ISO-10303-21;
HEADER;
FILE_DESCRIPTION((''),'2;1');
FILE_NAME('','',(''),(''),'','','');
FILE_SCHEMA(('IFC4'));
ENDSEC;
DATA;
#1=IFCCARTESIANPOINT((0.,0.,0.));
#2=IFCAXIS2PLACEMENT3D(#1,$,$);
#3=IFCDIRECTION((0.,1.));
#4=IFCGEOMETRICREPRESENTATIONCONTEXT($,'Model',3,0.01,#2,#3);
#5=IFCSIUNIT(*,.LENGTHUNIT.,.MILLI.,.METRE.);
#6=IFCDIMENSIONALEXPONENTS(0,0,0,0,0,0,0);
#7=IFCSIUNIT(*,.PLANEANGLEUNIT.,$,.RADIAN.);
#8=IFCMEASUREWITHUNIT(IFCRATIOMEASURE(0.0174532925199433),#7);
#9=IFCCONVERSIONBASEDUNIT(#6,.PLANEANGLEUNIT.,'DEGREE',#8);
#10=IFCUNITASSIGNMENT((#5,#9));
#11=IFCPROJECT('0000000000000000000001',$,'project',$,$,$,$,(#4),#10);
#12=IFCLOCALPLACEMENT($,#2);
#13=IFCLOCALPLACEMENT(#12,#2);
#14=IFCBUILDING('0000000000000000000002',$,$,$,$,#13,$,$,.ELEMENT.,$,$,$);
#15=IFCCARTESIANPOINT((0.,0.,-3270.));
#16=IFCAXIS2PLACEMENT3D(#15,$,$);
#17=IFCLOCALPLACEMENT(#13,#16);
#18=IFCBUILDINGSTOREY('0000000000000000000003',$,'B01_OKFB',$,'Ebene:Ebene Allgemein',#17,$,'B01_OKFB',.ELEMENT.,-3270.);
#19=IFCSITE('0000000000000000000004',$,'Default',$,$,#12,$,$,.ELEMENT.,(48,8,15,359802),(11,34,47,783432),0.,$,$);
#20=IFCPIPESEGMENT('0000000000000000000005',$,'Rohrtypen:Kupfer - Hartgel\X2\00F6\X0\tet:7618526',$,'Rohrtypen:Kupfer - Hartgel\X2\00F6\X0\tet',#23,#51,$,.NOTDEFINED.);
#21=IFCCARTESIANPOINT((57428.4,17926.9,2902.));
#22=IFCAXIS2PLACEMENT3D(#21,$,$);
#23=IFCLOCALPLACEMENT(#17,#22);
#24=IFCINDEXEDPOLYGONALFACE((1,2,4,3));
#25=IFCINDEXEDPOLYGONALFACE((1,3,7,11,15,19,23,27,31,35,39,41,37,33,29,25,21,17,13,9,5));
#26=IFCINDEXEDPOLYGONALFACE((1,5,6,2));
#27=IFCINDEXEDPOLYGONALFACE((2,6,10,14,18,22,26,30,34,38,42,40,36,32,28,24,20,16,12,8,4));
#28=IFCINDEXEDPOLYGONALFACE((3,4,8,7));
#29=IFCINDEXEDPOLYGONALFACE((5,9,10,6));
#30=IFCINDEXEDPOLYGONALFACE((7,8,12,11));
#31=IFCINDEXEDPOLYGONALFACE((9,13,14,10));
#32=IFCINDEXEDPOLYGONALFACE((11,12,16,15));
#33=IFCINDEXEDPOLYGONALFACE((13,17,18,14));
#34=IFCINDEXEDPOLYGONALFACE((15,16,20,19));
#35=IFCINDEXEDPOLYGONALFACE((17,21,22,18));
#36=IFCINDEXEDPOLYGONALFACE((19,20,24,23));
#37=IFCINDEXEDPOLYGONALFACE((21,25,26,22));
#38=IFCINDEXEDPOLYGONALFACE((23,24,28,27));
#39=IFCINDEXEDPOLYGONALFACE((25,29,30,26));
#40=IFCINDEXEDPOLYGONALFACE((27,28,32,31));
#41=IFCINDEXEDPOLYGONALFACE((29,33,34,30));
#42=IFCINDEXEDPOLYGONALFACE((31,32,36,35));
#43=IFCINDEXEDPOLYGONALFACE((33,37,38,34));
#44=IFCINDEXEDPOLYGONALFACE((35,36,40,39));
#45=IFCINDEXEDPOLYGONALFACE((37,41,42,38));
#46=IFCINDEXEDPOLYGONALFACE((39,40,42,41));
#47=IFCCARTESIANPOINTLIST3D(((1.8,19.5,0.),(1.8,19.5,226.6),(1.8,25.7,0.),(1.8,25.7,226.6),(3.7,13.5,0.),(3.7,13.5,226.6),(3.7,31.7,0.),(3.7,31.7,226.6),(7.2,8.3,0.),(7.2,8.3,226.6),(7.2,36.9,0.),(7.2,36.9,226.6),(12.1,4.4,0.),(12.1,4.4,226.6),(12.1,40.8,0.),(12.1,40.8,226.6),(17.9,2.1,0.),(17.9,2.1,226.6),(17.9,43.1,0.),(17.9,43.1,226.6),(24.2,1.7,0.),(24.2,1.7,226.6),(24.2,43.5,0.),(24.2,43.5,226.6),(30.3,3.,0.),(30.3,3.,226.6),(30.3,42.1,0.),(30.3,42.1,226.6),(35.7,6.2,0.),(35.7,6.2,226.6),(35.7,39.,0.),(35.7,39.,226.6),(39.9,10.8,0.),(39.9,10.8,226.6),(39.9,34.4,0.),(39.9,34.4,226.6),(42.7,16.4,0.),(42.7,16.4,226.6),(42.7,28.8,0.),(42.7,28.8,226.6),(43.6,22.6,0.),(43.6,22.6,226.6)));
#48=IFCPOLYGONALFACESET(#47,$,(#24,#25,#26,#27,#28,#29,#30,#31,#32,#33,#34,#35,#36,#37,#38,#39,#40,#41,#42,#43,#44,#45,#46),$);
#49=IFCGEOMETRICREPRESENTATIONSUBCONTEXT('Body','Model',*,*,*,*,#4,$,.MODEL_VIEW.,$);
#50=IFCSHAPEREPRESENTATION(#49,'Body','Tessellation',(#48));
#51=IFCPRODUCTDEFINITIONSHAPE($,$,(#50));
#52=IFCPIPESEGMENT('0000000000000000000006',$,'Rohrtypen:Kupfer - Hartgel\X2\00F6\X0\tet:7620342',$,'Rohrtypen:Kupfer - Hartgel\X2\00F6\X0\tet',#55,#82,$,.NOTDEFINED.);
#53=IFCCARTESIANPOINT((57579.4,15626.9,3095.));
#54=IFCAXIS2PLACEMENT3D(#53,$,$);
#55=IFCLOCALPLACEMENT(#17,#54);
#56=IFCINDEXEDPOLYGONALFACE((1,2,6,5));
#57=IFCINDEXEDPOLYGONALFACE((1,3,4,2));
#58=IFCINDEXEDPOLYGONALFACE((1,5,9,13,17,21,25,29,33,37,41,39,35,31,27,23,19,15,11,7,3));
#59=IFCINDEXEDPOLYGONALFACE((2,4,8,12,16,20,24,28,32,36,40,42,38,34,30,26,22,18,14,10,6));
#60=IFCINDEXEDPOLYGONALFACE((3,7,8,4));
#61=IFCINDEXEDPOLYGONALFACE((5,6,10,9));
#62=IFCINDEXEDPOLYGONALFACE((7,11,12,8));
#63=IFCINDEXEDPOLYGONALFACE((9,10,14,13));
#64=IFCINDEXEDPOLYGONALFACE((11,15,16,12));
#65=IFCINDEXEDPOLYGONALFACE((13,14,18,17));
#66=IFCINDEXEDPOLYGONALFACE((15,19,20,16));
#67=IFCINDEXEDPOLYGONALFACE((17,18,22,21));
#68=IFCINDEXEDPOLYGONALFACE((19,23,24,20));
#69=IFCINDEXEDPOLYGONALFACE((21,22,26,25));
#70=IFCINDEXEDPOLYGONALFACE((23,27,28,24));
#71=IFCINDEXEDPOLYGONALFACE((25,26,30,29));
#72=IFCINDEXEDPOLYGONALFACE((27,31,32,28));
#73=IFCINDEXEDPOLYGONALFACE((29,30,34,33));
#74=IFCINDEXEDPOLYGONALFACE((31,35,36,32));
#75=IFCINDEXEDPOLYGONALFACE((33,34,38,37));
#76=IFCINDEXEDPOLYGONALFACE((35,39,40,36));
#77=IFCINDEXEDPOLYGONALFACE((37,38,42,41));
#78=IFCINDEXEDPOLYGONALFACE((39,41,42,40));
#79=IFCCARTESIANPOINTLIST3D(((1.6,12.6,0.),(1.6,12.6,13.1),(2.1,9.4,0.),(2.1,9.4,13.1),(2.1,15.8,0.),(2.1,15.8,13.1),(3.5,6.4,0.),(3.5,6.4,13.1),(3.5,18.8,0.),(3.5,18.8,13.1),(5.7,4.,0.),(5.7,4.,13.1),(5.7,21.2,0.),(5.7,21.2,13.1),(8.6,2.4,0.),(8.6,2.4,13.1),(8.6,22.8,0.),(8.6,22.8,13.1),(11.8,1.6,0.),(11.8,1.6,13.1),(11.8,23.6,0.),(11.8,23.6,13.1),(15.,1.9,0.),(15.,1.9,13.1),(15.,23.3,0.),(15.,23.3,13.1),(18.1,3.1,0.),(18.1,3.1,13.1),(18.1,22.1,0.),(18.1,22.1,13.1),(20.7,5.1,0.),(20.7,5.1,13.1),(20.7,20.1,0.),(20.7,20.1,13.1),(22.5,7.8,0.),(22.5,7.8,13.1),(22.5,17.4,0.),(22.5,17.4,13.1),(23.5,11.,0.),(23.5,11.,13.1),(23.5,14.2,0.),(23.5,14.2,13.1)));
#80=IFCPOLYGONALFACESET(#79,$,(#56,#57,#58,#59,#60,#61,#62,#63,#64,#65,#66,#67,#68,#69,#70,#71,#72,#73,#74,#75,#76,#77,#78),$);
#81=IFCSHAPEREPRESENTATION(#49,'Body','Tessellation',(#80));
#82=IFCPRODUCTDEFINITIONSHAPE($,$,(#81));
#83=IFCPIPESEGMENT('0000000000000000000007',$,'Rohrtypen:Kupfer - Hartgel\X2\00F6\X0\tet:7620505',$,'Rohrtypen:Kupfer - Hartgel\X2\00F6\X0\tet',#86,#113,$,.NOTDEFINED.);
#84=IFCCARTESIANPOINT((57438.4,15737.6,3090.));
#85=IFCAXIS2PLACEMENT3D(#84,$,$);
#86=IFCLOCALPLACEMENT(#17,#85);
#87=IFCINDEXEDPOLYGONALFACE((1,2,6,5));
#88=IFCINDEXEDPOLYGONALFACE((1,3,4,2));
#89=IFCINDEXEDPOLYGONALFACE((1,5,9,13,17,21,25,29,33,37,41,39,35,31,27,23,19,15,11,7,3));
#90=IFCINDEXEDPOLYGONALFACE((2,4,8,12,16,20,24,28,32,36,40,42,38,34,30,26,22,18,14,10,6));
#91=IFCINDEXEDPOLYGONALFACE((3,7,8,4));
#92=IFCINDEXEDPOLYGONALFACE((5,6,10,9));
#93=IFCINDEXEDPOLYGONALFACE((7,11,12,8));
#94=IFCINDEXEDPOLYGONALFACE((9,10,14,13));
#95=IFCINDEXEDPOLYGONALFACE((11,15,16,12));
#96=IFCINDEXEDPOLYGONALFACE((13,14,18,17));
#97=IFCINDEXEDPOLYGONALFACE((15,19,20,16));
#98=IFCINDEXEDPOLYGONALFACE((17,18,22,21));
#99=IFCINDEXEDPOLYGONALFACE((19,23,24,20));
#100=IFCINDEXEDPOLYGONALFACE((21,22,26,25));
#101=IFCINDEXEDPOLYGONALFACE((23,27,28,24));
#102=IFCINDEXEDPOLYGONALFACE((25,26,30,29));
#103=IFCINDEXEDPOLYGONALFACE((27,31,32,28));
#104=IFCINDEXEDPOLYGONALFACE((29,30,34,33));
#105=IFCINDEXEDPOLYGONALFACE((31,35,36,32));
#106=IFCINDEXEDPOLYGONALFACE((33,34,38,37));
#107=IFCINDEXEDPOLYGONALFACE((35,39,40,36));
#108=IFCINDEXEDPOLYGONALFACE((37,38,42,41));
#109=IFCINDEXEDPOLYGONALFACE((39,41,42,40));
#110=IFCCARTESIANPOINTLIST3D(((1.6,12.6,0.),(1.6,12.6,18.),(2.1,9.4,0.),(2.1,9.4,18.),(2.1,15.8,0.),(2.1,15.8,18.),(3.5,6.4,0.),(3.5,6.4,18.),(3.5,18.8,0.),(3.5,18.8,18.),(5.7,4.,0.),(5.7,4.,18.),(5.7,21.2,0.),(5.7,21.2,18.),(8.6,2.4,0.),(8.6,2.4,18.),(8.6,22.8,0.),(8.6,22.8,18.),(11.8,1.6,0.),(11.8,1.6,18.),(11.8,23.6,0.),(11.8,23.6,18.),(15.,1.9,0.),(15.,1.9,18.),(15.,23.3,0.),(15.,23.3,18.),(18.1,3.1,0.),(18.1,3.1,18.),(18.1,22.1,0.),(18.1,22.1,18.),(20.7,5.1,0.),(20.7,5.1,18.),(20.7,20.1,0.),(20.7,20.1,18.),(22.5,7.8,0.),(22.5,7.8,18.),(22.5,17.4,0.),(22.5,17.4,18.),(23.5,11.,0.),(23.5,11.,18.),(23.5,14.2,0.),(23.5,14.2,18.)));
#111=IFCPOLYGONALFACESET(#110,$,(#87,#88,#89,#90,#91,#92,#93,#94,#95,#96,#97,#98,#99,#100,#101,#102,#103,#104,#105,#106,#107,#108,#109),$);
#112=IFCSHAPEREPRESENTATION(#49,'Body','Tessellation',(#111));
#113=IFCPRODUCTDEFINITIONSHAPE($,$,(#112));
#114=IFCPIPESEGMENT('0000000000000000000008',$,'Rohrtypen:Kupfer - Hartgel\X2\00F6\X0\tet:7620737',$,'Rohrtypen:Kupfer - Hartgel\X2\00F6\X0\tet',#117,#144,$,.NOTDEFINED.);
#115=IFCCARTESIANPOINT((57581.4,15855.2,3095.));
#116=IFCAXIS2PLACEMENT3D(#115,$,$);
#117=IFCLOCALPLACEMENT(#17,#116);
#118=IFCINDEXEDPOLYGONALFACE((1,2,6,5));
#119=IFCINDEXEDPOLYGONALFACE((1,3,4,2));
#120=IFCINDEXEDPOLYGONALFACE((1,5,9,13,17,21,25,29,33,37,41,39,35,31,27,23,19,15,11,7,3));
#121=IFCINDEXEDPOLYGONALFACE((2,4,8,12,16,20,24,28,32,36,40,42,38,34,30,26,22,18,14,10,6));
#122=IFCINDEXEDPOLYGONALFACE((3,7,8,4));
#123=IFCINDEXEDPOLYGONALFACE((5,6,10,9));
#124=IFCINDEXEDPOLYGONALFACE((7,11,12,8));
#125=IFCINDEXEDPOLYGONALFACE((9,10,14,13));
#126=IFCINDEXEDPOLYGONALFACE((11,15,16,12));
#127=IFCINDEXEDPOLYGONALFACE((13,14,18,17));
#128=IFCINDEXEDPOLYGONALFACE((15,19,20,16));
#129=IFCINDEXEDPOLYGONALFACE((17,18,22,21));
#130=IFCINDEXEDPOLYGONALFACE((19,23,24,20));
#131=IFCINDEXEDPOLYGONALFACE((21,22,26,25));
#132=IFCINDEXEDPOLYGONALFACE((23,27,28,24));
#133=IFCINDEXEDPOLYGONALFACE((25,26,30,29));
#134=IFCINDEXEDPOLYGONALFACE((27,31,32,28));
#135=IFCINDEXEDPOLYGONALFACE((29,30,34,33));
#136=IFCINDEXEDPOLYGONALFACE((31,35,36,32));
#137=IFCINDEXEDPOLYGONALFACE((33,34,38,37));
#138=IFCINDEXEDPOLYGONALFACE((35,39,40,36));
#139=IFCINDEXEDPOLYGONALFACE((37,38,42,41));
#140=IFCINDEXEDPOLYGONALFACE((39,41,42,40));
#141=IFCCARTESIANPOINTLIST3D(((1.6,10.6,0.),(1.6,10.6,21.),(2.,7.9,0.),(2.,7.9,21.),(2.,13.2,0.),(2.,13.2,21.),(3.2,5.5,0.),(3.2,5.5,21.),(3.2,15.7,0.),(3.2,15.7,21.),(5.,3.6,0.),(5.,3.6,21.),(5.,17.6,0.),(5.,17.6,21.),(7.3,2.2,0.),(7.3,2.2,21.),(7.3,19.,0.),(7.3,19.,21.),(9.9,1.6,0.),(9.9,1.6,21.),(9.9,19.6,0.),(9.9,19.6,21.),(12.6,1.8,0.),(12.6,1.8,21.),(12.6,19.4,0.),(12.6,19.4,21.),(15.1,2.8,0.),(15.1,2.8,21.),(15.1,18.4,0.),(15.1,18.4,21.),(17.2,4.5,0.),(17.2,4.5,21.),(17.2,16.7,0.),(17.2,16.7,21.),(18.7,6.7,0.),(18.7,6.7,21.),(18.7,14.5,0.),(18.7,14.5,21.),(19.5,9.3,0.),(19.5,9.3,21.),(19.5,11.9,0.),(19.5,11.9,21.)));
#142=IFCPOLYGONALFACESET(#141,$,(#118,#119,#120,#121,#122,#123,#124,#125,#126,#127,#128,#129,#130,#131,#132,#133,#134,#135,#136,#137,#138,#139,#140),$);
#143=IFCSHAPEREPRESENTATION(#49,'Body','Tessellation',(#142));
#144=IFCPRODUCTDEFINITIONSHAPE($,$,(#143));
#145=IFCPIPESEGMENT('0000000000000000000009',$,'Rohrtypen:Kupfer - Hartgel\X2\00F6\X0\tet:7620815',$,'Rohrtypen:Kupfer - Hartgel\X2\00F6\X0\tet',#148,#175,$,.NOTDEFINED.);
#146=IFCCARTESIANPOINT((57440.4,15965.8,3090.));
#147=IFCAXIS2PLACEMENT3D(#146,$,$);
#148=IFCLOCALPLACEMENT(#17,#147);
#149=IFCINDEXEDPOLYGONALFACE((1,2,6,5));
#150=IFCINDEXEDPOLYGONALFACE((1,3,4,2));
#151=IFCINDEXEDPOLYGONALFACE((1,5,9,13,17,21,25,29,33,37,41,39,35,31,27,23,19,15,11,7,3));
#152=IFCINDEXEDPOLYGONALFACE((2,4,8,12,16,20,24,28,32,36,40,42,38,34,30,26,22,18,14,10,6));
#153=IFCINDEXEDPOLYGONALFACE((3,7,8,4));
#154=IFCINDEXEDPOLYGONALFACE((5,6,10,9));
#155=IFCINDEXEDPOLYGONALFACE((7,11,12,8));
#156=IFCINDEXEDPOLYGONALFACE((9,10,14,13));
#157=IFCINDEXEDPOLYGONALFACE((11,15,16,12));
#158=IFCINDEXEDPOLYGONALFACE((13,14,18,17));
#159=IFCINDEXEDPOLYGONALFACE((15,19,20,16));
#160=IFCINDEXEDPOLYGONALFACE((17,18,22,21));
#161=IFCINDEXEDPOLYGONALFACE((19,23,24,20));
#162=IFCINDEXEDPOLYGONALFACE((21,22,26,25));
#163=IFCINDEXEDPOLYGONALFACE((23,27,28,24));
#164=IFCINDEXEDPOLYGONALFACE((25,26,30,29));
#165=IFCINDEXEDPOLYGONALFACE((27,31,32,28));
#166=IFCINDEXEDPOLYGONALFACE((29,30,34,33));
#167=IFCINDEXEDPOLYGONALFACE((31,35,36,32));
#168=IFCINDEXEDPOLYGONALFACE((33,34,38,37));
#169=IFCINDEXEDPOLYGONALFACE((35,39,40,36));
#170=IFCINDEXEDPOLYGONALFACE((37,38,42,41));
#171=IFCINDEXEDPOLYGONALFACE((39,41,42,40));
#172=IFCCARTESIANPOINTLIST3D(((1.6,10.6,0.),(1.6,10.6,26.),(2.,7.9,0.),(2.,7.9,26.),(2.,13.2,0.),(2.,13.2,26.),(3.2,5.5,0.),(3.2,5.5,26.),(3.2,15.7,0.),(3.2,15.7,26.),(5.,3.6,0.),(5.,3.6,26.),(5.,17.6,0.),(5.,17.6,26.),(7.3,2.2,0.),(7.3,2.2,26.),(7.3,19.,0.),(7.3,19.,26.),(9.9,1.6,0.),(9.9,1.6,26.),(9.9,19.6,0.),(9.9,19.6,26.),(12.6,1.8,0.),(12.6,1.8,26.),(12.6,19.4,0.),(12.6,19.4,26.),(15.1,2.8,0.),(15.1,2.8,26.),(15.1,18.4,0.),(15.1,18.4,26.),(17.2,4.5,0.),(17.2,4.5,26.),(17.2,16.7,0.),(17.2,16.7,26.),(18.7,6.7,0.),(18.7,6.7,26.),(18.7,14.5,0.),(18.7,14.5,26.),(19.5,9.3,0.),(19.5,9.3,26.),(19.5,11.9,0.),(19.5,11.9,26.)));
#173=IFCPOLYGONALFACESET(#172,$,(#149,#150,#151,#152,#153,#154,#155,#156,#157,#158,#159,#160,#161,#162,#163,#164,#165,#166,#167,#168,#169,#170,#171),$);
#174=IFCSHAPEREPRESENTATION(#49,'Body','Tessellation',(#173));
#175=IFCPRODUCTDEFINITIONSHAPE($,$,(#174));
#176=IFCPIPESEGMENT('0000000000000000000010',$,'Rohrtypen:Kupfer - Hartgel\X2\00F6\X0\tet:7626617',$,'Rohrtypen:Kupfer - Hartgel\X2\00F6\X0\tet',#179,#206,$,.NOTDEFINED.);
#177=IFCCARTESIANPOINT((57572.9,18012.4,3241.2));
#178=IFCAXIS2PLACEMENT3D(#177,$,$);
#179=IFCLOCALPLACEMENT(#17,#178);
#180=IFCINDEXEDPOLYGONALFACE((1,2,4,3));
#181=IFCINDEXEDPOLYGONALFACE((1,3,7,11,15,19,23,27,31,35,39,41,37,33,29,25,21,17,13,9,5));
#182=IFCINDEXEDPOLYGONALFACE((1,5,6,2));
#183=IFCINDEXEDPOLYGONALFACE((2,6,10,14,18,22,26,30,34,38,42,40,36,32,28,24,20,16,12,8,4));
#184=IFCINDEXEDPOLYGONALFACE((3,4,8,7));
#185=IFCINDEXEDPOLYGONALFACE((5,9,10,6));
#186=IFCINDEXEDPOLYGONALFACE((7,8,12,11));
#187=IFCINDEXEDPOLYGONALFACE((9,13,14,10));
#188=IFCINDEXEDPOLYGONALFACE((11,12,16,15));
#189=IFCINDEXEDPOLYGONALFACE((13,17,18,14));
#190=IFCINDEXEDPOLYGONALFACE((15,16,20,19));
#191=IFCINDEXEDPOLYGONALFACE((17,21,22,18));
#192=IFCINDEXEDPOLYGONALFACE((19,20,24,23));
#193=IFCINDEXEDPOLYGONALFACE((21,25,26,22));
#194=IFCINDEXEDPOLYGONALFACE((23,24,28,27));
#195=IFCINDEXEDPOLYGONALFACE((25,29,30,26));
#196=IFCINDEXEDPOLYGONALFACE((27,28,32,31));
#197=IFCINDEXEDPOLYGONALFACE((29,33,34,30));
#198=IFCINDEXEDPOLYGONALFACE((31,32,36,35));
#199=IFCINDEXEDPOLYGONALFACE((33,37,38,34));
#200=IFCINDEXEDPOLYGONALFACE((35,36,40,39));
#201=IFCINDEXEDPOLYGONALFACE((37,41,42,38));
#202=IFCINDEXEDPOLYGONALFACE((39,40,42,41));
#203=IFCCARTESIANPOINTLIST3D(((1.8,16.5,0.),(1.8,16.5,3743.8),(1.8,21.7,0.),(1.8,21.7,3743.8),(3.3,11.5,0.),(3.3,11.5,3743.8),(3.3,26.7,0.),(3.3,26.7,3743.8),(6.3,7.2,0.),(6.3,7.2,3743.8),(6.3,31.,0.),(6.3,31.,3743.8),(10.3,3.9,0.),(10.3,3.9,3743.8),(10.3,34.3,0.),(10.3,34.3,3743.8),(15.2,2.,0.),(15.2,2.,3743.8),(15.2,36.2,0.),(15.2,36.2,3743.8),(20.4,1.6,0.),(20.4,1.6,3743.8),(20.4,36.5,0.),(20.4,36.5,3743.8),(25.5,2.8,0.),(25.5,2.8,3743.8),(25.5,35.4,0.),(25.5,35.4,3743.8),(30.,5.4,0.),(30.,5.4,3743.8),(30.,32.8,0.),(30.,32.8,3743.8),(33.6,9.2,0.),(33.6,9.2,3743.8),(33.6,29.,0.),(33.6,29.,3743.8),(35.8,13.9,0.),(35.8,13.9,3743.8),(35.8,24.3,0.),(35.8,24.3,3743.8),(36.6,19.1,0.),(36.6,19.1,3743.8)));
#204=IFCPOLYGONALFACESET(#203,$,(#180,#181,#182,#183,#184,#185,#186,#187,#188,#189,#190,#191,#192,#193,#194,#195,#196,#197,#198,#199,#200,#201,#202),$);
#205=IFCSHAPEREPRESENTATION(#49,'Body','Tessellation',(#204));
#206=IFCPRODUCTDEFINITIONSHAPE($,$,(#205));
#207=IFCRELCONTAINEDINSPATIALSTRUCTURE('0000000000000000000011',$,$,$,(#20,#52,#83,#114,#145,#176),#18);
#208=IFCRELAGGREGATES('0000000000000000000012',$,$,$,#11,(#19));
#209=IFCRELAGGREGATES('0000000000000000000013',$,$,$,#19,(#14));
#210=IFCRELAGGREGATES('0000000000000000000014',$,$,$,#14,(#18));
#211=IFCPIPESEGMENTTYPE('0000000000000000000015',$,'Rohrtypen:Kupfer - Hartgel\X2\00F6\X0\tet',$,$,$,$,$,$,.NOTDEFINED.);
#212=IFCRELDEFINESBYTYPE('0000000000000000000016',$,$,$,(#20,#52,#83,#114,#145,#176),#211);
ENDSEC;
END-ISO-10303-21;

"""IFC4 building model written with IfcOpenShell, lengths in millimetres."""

from ifc_helpers import new_model, entity, si_unit, converted_unit, direction, frame, frame_2d, origin, origin_2d_with_axis, place, context, subcontext, project, spatial, circle, extrude, type_object, element, save


model = new_model("IFC4")

# Units and contexts
model_context = context("Model", 3, precision=0.01, world=origin(), true_north=direction((0.0, 1.0)))
body_context = subcontext(model_context, "Body", "Model", "MODEL_VIEW")
ifc_project = project(units=[si_unit("LENGTHUNIT", "METRE", prefix="MILLI"), converted_unit("PLANEANGLEUNIT", "DEGREE", entity("IfcRatioMeasure", 0.0174532925199433), si_unit("PLANEANGLEUNIT", "RADIAN"), dimensions=[0, 0, 0, 0, 0, 0, 0])], contexts=[model_context])

# Site, building, storey
site_placement = place(None, origin())
site = spatial("IfcSite", under=ifc_project, at=site_placement, Name="Default", CompositionType="ELEMENT", RefLatitude=(48, 8, 15, 359802), RefLongitude=(11, 34, 47, 783432), RefElevation=0.0)
building_placement = place(site_placement, origin())
building = spatial("IfcBuilding", under=site, at=building_placement, CompositionType="ELEMENT")
storey_placement = place(building_placement, frame((0.0, 0.0, -3270.0)))
storey = spatial("IfcBuildingStorey", under=building, at=storey_placement, Name="B01_OKFB", ObjectType="Ebene:Ebene Allgemein", LongName="B01_OKFB", CompositionType="ELEMENT", Elevation=-3270.0)

# Pipe segments
pipe_segment_type = type_object("IfcPipeSegmentType", Name="Rohrtypen:Kupfer - Hartgelötet", PredefinedType="NOTDEFINED")
pipe_segment_1_placement = place(storey_placement, frame((57428.4, 17926.9, 2902.0)))
element("IfcPipeSegment", 1, at=pipe_segment_1_placement, inside=storey, type_object=pipe_segment_type, Name="Rohrtypen:Kupfer - Hartgelötet:7618526", ObjectType="Rohrtypen:Kupfer - Hartgelötet", PredefinedType="NOTDEFINED", context=body_context, shape_type="SweptSolid", body=[
    extrude(circle(Radius=21.0, at=origin_2d_with_axis()), frame((22.6, 22.6, 0.0)), (0.0, 0.0, 1.0), 226.6),
])
pipe_segment_2_placement = place(storey_placement, frame((57579.4, 15626.9, 3095.0)))
element("IfcPipeSegment", 2, at=pipe_segment_2_placement, inside=storey, type_object=pipe_segment_type, Name="Rohrtypen:Kupfer - Hartgelötet:7620342", ObjectType="Rohrtypen:Kupfer - Hartgelötet", PredefinedType="NOTDEFINED", context=body_context, shape_type="SweptSolid", body=[
    extrude(circle(Radius=11.0, at=frame_2d((0.0, 0.0), x_axis=(1.0, 0.0))), frame((12.6, 12.6, 0.0), z_axis=(0.0, 0.0, 1.0), x_axis=(-1.0, 0.0, 0.0)), (0.0, 0.0, 1.0), 13.1),
])
pipe_segment_3_placement = place(storey_placement, frame((57438.4, 15737.6, 3090.0)))
element("IfcPipeSegment", 3, at=pipe_segment_3_placement, inside=storey, type_object=pipe_segment_type, Name="Rohrtypen:Kupfer - Hartgelötet:7620505", ObjectType="Rohrtypen:Kupfer - Hartgelötet", PredefinedType="NOTDEFINED", context=body_context, shape_type="SweptSolid", body=[
    extrude(circle(Radius=11.0, at=origin_2d_with_axis()), frame((12.6, 12.6, 0.0), z_axis=(0.0, 0.0, 1.0), x_axis=(-1.0, 0.0, 0.0)), (0.0, 0.0, 1.0), 18.0),
])
pipe_segment_4_placement = place(storey_placement, frame((57581.4, 15855.2, 3095.0)))
element("IfcPipeSegment", 4, at=pipe_segment_4_placement, inside=storey, type_object=pipe_segment_type, Name="Rohrtypen:Kupfer - Hartgelötet:7620737", ObjectType="Rohrtypen:Kupfer - Hartgelötet", PredefinedType="NOTDEFINED", context=body_context, shape_type="SweptSolid", body=[
    extrude(circle(Radius=9.0, at=origin_2d_with_axis()), frame((10.6, 10.6, 0.0), z_axis=(0.0, 0.0, 1.0), x_axis=(-1.0, 0.0, 0.0)), (0.0, 0.0, 1.0), 21.0),
])
pipe_segment_5_placement = place(storey_placement, frame((57440.4, 15965.8, 3090.0)))
element("IfcPipeSegment", 5, at=pipe_segment_5_placement, inside=storey, type_object=pipe_segment_type, Name="Rohrtypen:Kupfer - Hartgelötet:7620815", ObjectType="Rohrtypen:Kupfer - Hartgelötet", PredefinedType="NOTDEFINED", context=body_context, shape_type="SweptSolid", body=[
    extrude(circle(Radius=9.0, at=origin_2d_with_axis()), frame((10.6, 10.6, 0.0), z_axis=(0.0, 0.0, 1.0), x_axis=(-1.0, 0.0, 0.0)), (0.0, 0.0, 1.0), 26.0),
])
pipe_segment_6_placement = place(storey_placement, frame((57572.9, 18012.4, 3241.2)))
element("IfcPipeSegment", 6, at=pipe_segment_6_placement, inside=storey, type_object=pipe_segment_type, Name="Rohrtypen:Kupfer - Hartgelötet:7626617", ObjectType="Rohrtypen:Kupfer - Hartgelötet", PredefinedType="NOTDEFINED", context=body_context, shape_type="SweptSolid", body=[
    extrude(circle(Radius=17.5, at=origin_2d_with_axis()), frame((19.1, 19.1, 0.0)), (0.0, 0.0, 1.0), 3743.8),
])

save(model, "model.ifc")
